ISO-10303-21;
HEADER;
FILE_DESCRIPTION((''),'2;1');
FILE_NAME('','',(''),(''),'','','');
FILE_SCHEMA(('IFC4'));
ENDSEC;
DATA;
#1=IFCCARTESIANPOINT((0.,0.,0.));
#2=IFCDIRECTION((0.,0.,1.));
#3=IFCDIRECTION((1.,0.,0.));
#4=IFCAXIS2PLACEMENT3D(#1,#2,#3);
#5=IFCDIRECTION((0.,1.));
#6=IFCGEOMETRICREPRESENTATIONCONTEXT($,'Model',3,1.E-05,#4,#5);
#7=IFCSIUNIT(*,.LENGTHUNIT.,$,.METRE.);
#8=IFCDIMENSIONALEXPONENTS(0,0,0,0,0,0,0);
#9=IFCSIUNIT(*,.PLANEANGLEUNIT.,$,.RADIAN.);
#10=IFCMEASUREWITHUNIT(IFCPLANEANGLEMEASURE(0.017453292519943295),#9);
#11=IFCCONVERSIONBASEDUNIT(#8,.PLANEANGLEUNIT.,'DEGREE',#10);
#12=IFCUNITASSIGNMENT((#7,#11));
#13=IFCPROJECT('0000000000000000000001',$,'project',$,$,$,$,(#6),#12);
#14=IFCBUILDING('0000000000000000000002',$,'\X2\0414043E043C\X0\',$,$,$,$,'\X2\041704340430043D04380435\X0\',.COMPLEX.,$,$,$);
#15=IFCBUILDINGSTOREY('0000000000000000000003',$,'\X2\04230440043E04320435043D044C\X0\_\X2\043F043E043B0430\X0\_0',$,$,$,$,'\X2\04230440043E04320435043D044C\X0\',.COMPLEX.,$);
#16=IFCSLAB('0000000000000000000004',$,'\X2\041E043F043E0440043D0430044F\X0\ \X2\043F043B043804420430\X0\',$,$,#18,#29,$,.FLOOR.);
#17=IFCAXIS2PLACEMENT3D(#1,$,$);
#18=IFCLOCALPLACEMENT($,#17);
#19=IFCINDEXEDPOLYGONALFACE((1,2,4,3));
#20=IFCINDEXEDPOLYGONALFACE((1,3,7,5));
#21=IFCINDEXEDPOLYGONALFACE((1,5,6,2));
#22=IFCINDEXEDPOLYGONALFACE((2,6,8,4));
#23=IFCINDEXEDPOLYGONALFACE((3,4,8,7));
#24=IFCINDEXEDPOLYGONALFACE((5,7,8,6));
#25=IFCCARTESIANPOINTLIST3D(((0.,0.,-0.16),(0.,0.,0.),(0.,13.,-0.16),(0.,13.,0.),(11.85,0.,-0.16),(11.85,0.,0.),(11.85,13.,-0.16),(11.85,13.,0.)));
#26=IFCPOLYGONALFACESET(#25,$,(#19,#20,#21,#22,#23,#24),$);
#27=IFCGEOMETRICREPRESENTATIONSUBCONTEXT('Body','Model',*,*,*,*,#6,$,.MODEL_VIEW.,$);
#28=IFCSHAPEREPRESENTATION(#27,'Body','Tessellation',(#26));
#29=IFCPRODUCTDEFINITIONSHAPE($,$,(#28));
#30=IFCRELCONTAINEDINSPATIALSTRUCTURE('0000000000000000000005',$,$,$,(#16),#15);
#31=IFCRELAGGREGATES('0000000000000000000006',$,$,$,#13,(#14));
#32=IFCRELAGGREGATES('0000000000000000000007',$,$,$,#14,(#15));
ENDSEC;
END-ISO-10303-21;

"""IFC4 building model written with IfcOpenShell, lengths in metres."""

from ifc_helpers import new_model, entity, si_unit, converted_unit, direction, frame, origin_with_axes, origin_2d_with_axis, place, context, subcontext, project, spatial, rectangle, extrude, element, save


model = new_model("IFC4")

# Units and contexts
model_context = context("Model", 3, precision=1e-05, world=origin_with_axes(), true_north=direction((0.0, 1.0)))
body_context = subcontext(model_context, "Body", "Model", "MODEL_VIEW")
ifc_project = project(units=[si_unit("LENGTHUNIT", "METRE"), converted_unit("PLANEANGLEUNIT", "DEGREE", entity("IfcPlaneAngleMeasure", 0.017453292519943295), si_unit("PLANEANGLEUNIT", "RADIAN"), dimensions=[0, 0, 0, 0, 0, 0, 0])], contexts=[model_context])

# Building, storey
building = spatial("IfcBuilding", under=ifc_project, Name="Дом", LongName="Здание", CompositionType="COMPLEX")
storey = spatial("IfcBuildingStorey", under=building, Name="Уровень_пола_0", LongName="Уровень", CompositionType="COMPLEX")

# Slab
slab_placement = place(None, origin_with_axes())
element("IfcSlab", 1, at=slab_placement, inside=storey, Name="Опорная плита", PredefinedType="FLOOR", context=body_context, shape_type="SweptSolid", body=[
    extrude(rectangle(XDim=11.85, YDim=13.0, at=origin_2d_with_axis()), frame((5.925, 6.5, 0.0), z_axis=(0.0, 0.0, 1.0), x_axis=(1.0, 0.0, 0.0)), (0.0, 0.0, -1.0), 0.16),
])

save(model, "model.ifc")
